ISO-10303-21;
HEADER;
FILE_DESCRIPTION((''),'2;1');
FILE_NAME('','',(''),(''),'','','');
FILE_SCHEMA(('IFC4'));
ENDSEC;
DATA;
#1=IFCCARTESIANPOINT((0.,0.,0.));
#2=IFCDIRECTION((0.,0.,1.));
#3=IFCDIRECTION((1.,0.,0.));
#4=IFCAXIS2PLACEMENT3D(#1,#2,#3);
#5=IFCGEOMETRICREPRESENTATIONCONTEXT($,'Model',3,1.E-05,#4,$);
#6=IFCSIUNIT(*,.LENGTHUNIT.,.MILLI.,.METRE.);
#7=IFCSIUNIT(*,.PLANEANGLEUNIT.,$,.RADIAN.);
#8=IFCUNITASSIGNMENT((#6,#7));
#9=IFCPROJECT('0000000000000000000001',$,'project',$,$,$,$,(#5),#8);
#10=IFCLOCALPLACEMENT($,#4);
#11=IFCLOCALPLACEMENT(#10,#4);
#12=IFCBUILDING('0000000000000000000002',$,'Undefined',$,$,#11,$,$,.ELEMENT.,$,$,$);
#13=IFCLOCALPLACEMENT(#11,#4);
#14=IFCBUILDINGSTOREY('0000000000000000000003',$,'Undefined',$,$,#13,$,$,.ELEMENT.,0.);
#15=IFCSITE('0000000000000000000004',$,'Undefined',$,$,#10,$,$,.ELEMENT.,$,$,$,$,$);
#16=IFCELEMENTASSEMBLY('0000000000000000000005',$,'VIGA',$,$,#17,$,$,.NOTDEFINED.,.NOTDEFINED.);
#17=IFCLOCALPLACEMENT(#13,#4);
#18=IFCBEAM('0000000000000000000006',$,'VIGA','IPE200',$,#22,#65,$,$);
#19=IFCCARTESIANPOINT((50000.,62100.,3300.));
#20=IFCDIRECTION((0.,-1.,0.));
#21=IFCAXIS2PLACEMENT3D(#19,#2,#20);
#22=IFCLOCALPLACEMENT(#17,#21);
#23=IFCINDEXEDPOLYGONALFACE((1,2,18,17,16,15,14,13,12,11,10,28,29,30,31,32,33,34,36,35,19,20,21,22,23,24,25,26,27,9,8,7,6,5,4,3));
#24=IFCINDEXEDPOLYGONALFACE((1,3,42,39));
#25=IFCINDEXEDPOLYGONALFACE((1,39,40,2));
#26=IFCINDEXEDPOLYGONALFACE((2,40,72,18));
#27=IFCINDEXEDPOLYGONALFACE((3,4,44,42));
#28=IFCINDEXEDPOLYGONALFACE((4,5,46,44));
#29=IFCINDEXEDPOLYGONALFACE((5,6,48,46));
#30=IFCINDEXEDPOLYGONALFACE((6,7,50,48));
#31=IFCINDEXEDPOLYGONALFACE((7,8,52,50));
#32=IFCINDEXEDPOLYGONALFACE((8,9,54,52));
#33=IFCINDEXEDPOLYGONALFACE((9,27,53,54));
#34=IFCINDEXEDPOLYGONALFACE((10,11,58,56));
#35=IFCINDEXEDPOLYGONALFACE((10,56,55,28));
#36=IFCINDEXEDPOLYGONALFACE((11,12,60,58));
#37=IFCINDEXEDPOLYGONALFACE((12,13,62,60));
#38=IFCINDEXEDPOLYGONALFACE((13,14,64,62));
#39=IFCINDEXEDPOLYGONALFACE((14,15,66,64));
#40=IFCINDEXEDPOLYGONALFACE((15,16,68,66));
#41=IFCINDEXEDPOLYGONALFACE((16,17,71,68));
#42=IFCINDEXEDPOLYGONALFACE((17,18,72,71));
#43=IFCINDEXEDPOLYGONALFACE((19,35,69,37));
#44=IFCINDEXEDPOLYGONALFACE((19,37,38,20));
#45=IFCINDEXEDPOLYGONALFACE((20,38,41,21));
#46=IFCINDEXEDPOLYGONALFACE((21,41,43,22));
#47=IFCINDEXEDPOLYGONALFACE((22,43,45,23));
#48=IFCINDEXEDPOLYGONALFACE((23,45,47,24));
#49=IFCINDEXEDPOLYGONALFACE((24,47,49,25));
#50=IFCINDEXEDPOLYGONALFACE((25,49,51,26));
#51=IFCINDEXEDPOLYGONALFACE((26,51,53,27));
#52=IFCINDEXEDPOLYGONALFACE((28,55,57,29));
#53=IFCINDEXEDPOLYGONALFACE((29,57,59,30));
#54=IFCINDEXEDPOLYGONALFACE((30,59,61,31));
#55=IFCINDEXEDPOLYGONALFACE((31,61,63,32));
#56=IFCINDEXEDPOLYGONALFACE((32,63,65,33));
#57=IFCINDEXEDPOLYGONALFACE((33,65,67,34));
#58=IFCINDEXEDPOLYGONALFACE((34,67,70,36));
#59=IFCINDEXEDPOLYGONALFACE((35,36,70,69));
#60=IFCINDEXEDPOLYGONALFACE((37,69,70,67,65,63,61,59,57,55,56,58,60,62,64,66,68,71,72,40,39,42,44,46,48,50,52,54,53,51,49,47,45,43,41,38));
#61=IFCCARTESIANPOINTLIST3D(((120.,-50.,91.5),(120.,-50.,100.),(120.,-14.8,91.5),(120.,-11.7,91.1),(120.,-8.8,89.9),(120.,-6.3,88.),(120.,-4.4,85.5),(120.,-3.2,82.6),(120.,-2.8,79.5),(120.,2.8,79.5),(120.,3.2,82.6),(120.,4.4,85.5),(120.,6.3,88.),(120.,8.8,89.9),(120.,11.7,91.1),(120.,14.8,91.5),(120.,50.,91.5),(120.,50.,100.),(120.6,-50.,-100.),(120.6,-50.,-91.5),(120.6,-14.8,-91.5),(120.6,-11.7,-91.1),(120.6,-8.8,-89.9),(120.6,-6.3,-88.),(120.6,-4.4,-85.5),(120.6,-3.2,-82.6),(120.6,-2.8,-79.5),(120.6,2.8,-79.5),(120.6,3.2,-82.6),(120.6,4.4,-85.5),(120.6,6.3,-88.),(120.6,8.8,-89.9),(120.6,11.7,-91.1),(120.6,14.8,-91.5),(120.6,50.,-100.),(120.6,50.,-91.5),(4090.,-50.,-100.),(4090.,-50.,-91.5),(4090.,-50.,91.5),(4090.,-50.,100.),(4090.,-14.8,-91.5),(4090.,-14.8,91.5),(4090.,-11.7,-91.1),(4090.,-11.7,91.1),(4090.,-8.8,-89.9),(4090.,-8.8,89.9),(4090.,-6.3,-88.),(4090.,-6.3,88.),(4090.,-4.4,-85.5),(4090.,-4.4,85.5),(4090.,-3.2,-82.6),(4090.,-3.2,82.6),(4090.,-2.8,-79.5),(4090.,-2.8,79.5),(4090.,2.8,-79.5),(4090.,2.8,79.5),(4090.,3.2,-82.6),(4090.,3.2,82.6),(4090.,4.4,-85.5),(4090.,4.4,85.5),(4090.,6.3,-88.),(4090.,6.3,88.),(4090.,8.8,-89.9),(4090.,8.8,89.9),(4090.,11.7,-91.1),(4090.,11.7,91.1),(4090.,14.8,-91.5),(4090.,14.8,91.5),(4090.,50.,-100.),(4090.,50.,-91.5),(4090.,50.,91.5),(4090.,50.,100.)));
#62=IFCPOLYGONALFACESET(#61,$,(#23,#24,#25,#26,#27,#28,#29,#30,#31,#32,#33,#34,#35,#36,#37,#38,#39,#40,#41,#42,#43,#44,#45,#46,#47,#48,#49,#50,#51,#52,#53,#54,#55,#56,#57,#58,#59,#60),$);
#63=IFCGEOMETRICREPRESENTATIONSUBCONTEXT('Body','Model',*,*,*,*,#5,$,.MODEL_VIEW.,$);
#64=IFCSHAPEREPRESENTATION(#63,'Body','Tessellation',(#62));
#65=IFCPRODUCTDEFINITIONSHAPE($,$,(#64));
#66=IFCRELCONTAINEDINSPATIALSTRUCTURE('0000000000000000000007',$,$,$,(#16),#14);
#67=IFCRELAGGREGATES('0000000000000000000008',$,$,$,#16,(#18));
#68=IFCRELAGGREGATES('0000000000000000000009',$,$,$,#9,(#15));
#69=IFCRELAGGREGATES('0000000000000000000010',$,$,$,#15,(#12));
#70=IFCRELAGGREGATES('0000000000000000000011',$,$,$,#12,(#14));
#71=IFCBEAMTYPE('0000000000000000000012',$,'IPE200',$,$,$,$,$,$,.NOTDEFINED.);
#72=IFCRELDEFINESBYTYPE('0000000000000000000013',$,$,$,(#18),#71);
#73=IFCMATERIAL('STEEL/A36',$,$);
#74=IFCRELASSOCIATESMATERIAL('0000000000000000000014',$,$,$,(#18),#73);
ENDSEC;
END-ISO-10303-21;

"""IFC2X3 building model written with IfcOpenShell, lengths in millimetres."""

from ifc_helpers import new_model, si_unit, frame, origin_with_axes, origin_2d_with_axis, place, context, subcontext, project, spatial, i_section, extrude, clip, halfspace, material, type_object, element, aggregate, save


model = new_model("IFC2X3")

# Units and contexts
model_context = context("Model", 3, precision=1e-05, world=origin_with_axes())
body_context = subcontext(model_context, "Body", "Model", "MODEL_VIEW")
ifc_project = project(units=[si_unit("LENGTHUNIT", "METRE", prefix="MILLI"), si_unit("PLANEANGLEUNIT", "RADIAN")], contexts=[model_context])

# Site, building, storey
site_placement = place(None, origin_with_axes())
site = spatial("IfcSite", under=ifc_project, at=site_placement, Name="Undefined", CompositionType="ELEMENT")
building_placement = place(site_placement, origin_with_axes())
building = spatial("IfcBuilding", under=site, at=building_placement, Name="Undefined", CompositionType="ELEMENT")
storey_placement = place(building_placement, origin_with_axes())
storey = spatial("IfcBuildingStorey", under=building, at=storey_placement, Name="Undefined", CompositionType="ELEMENT", Elevation=0.0)

# Shared definitions
ifc_material_1 = material(Name="STEEL/A36")

# Element assembly, beam
assembly_1_placement = place(storey_placement, origin_with_axes())
assembly_1 = element("IfcElementAssembly", 1, at=assembly_1_placement, inside=storey, Name="VIGA", AssemblyPlace="NOTDEFINED", PredefinedType="NOTDEFINED")
beam_type_1 = type_object("IfcBeamType", Name="IPE200", PredefinedType="NOTDEFINED")
beam_1_placement = place(assembly_1_placement, frame((50000.0, 62100.0, 3300.0), z_axis=(0.0, 0.0, 1.0), x_axis=(0.0, -1.0, 0.0)))
beam_1 = element("IfcBeam", 2, at=beam_1_placement, type_object=beam_type_1, material=ifc_material_1, Name="VIGA", Description="IPE200", context=body_context, shape_type="Clipping", body=[
    clip(clip(extrude(i_section(OverallWidth=100.0, OverallDepth=200.0, WebThickness=5.6, FlangeThickness=8.5, FilletRadius=12.0, at=origin_2d_with_axis()), frame((4200.0, 0.0, 0.0), z_axis=(-1.0, 0.0, 0.0), x_axis=(0.0, -1.0, 0.0)), (0.0, 0.0, 1.0), 4200.0), halfspace(frame((4090.0, -400.0, 200.0), z_axis=(1.0, 0.0, 0.0), x_axis=(0.0, 1.0, 0.0)), False)), halfspace(frame((120.0, 0.0, 100.0), z_axis=(-0.999995, 0.0, -0.003301), x_axis=(0.0, -1.0, 0.0)), False)),
])

aggregate(assembly_1, [beam_1])

save(model, "model.ifc")
